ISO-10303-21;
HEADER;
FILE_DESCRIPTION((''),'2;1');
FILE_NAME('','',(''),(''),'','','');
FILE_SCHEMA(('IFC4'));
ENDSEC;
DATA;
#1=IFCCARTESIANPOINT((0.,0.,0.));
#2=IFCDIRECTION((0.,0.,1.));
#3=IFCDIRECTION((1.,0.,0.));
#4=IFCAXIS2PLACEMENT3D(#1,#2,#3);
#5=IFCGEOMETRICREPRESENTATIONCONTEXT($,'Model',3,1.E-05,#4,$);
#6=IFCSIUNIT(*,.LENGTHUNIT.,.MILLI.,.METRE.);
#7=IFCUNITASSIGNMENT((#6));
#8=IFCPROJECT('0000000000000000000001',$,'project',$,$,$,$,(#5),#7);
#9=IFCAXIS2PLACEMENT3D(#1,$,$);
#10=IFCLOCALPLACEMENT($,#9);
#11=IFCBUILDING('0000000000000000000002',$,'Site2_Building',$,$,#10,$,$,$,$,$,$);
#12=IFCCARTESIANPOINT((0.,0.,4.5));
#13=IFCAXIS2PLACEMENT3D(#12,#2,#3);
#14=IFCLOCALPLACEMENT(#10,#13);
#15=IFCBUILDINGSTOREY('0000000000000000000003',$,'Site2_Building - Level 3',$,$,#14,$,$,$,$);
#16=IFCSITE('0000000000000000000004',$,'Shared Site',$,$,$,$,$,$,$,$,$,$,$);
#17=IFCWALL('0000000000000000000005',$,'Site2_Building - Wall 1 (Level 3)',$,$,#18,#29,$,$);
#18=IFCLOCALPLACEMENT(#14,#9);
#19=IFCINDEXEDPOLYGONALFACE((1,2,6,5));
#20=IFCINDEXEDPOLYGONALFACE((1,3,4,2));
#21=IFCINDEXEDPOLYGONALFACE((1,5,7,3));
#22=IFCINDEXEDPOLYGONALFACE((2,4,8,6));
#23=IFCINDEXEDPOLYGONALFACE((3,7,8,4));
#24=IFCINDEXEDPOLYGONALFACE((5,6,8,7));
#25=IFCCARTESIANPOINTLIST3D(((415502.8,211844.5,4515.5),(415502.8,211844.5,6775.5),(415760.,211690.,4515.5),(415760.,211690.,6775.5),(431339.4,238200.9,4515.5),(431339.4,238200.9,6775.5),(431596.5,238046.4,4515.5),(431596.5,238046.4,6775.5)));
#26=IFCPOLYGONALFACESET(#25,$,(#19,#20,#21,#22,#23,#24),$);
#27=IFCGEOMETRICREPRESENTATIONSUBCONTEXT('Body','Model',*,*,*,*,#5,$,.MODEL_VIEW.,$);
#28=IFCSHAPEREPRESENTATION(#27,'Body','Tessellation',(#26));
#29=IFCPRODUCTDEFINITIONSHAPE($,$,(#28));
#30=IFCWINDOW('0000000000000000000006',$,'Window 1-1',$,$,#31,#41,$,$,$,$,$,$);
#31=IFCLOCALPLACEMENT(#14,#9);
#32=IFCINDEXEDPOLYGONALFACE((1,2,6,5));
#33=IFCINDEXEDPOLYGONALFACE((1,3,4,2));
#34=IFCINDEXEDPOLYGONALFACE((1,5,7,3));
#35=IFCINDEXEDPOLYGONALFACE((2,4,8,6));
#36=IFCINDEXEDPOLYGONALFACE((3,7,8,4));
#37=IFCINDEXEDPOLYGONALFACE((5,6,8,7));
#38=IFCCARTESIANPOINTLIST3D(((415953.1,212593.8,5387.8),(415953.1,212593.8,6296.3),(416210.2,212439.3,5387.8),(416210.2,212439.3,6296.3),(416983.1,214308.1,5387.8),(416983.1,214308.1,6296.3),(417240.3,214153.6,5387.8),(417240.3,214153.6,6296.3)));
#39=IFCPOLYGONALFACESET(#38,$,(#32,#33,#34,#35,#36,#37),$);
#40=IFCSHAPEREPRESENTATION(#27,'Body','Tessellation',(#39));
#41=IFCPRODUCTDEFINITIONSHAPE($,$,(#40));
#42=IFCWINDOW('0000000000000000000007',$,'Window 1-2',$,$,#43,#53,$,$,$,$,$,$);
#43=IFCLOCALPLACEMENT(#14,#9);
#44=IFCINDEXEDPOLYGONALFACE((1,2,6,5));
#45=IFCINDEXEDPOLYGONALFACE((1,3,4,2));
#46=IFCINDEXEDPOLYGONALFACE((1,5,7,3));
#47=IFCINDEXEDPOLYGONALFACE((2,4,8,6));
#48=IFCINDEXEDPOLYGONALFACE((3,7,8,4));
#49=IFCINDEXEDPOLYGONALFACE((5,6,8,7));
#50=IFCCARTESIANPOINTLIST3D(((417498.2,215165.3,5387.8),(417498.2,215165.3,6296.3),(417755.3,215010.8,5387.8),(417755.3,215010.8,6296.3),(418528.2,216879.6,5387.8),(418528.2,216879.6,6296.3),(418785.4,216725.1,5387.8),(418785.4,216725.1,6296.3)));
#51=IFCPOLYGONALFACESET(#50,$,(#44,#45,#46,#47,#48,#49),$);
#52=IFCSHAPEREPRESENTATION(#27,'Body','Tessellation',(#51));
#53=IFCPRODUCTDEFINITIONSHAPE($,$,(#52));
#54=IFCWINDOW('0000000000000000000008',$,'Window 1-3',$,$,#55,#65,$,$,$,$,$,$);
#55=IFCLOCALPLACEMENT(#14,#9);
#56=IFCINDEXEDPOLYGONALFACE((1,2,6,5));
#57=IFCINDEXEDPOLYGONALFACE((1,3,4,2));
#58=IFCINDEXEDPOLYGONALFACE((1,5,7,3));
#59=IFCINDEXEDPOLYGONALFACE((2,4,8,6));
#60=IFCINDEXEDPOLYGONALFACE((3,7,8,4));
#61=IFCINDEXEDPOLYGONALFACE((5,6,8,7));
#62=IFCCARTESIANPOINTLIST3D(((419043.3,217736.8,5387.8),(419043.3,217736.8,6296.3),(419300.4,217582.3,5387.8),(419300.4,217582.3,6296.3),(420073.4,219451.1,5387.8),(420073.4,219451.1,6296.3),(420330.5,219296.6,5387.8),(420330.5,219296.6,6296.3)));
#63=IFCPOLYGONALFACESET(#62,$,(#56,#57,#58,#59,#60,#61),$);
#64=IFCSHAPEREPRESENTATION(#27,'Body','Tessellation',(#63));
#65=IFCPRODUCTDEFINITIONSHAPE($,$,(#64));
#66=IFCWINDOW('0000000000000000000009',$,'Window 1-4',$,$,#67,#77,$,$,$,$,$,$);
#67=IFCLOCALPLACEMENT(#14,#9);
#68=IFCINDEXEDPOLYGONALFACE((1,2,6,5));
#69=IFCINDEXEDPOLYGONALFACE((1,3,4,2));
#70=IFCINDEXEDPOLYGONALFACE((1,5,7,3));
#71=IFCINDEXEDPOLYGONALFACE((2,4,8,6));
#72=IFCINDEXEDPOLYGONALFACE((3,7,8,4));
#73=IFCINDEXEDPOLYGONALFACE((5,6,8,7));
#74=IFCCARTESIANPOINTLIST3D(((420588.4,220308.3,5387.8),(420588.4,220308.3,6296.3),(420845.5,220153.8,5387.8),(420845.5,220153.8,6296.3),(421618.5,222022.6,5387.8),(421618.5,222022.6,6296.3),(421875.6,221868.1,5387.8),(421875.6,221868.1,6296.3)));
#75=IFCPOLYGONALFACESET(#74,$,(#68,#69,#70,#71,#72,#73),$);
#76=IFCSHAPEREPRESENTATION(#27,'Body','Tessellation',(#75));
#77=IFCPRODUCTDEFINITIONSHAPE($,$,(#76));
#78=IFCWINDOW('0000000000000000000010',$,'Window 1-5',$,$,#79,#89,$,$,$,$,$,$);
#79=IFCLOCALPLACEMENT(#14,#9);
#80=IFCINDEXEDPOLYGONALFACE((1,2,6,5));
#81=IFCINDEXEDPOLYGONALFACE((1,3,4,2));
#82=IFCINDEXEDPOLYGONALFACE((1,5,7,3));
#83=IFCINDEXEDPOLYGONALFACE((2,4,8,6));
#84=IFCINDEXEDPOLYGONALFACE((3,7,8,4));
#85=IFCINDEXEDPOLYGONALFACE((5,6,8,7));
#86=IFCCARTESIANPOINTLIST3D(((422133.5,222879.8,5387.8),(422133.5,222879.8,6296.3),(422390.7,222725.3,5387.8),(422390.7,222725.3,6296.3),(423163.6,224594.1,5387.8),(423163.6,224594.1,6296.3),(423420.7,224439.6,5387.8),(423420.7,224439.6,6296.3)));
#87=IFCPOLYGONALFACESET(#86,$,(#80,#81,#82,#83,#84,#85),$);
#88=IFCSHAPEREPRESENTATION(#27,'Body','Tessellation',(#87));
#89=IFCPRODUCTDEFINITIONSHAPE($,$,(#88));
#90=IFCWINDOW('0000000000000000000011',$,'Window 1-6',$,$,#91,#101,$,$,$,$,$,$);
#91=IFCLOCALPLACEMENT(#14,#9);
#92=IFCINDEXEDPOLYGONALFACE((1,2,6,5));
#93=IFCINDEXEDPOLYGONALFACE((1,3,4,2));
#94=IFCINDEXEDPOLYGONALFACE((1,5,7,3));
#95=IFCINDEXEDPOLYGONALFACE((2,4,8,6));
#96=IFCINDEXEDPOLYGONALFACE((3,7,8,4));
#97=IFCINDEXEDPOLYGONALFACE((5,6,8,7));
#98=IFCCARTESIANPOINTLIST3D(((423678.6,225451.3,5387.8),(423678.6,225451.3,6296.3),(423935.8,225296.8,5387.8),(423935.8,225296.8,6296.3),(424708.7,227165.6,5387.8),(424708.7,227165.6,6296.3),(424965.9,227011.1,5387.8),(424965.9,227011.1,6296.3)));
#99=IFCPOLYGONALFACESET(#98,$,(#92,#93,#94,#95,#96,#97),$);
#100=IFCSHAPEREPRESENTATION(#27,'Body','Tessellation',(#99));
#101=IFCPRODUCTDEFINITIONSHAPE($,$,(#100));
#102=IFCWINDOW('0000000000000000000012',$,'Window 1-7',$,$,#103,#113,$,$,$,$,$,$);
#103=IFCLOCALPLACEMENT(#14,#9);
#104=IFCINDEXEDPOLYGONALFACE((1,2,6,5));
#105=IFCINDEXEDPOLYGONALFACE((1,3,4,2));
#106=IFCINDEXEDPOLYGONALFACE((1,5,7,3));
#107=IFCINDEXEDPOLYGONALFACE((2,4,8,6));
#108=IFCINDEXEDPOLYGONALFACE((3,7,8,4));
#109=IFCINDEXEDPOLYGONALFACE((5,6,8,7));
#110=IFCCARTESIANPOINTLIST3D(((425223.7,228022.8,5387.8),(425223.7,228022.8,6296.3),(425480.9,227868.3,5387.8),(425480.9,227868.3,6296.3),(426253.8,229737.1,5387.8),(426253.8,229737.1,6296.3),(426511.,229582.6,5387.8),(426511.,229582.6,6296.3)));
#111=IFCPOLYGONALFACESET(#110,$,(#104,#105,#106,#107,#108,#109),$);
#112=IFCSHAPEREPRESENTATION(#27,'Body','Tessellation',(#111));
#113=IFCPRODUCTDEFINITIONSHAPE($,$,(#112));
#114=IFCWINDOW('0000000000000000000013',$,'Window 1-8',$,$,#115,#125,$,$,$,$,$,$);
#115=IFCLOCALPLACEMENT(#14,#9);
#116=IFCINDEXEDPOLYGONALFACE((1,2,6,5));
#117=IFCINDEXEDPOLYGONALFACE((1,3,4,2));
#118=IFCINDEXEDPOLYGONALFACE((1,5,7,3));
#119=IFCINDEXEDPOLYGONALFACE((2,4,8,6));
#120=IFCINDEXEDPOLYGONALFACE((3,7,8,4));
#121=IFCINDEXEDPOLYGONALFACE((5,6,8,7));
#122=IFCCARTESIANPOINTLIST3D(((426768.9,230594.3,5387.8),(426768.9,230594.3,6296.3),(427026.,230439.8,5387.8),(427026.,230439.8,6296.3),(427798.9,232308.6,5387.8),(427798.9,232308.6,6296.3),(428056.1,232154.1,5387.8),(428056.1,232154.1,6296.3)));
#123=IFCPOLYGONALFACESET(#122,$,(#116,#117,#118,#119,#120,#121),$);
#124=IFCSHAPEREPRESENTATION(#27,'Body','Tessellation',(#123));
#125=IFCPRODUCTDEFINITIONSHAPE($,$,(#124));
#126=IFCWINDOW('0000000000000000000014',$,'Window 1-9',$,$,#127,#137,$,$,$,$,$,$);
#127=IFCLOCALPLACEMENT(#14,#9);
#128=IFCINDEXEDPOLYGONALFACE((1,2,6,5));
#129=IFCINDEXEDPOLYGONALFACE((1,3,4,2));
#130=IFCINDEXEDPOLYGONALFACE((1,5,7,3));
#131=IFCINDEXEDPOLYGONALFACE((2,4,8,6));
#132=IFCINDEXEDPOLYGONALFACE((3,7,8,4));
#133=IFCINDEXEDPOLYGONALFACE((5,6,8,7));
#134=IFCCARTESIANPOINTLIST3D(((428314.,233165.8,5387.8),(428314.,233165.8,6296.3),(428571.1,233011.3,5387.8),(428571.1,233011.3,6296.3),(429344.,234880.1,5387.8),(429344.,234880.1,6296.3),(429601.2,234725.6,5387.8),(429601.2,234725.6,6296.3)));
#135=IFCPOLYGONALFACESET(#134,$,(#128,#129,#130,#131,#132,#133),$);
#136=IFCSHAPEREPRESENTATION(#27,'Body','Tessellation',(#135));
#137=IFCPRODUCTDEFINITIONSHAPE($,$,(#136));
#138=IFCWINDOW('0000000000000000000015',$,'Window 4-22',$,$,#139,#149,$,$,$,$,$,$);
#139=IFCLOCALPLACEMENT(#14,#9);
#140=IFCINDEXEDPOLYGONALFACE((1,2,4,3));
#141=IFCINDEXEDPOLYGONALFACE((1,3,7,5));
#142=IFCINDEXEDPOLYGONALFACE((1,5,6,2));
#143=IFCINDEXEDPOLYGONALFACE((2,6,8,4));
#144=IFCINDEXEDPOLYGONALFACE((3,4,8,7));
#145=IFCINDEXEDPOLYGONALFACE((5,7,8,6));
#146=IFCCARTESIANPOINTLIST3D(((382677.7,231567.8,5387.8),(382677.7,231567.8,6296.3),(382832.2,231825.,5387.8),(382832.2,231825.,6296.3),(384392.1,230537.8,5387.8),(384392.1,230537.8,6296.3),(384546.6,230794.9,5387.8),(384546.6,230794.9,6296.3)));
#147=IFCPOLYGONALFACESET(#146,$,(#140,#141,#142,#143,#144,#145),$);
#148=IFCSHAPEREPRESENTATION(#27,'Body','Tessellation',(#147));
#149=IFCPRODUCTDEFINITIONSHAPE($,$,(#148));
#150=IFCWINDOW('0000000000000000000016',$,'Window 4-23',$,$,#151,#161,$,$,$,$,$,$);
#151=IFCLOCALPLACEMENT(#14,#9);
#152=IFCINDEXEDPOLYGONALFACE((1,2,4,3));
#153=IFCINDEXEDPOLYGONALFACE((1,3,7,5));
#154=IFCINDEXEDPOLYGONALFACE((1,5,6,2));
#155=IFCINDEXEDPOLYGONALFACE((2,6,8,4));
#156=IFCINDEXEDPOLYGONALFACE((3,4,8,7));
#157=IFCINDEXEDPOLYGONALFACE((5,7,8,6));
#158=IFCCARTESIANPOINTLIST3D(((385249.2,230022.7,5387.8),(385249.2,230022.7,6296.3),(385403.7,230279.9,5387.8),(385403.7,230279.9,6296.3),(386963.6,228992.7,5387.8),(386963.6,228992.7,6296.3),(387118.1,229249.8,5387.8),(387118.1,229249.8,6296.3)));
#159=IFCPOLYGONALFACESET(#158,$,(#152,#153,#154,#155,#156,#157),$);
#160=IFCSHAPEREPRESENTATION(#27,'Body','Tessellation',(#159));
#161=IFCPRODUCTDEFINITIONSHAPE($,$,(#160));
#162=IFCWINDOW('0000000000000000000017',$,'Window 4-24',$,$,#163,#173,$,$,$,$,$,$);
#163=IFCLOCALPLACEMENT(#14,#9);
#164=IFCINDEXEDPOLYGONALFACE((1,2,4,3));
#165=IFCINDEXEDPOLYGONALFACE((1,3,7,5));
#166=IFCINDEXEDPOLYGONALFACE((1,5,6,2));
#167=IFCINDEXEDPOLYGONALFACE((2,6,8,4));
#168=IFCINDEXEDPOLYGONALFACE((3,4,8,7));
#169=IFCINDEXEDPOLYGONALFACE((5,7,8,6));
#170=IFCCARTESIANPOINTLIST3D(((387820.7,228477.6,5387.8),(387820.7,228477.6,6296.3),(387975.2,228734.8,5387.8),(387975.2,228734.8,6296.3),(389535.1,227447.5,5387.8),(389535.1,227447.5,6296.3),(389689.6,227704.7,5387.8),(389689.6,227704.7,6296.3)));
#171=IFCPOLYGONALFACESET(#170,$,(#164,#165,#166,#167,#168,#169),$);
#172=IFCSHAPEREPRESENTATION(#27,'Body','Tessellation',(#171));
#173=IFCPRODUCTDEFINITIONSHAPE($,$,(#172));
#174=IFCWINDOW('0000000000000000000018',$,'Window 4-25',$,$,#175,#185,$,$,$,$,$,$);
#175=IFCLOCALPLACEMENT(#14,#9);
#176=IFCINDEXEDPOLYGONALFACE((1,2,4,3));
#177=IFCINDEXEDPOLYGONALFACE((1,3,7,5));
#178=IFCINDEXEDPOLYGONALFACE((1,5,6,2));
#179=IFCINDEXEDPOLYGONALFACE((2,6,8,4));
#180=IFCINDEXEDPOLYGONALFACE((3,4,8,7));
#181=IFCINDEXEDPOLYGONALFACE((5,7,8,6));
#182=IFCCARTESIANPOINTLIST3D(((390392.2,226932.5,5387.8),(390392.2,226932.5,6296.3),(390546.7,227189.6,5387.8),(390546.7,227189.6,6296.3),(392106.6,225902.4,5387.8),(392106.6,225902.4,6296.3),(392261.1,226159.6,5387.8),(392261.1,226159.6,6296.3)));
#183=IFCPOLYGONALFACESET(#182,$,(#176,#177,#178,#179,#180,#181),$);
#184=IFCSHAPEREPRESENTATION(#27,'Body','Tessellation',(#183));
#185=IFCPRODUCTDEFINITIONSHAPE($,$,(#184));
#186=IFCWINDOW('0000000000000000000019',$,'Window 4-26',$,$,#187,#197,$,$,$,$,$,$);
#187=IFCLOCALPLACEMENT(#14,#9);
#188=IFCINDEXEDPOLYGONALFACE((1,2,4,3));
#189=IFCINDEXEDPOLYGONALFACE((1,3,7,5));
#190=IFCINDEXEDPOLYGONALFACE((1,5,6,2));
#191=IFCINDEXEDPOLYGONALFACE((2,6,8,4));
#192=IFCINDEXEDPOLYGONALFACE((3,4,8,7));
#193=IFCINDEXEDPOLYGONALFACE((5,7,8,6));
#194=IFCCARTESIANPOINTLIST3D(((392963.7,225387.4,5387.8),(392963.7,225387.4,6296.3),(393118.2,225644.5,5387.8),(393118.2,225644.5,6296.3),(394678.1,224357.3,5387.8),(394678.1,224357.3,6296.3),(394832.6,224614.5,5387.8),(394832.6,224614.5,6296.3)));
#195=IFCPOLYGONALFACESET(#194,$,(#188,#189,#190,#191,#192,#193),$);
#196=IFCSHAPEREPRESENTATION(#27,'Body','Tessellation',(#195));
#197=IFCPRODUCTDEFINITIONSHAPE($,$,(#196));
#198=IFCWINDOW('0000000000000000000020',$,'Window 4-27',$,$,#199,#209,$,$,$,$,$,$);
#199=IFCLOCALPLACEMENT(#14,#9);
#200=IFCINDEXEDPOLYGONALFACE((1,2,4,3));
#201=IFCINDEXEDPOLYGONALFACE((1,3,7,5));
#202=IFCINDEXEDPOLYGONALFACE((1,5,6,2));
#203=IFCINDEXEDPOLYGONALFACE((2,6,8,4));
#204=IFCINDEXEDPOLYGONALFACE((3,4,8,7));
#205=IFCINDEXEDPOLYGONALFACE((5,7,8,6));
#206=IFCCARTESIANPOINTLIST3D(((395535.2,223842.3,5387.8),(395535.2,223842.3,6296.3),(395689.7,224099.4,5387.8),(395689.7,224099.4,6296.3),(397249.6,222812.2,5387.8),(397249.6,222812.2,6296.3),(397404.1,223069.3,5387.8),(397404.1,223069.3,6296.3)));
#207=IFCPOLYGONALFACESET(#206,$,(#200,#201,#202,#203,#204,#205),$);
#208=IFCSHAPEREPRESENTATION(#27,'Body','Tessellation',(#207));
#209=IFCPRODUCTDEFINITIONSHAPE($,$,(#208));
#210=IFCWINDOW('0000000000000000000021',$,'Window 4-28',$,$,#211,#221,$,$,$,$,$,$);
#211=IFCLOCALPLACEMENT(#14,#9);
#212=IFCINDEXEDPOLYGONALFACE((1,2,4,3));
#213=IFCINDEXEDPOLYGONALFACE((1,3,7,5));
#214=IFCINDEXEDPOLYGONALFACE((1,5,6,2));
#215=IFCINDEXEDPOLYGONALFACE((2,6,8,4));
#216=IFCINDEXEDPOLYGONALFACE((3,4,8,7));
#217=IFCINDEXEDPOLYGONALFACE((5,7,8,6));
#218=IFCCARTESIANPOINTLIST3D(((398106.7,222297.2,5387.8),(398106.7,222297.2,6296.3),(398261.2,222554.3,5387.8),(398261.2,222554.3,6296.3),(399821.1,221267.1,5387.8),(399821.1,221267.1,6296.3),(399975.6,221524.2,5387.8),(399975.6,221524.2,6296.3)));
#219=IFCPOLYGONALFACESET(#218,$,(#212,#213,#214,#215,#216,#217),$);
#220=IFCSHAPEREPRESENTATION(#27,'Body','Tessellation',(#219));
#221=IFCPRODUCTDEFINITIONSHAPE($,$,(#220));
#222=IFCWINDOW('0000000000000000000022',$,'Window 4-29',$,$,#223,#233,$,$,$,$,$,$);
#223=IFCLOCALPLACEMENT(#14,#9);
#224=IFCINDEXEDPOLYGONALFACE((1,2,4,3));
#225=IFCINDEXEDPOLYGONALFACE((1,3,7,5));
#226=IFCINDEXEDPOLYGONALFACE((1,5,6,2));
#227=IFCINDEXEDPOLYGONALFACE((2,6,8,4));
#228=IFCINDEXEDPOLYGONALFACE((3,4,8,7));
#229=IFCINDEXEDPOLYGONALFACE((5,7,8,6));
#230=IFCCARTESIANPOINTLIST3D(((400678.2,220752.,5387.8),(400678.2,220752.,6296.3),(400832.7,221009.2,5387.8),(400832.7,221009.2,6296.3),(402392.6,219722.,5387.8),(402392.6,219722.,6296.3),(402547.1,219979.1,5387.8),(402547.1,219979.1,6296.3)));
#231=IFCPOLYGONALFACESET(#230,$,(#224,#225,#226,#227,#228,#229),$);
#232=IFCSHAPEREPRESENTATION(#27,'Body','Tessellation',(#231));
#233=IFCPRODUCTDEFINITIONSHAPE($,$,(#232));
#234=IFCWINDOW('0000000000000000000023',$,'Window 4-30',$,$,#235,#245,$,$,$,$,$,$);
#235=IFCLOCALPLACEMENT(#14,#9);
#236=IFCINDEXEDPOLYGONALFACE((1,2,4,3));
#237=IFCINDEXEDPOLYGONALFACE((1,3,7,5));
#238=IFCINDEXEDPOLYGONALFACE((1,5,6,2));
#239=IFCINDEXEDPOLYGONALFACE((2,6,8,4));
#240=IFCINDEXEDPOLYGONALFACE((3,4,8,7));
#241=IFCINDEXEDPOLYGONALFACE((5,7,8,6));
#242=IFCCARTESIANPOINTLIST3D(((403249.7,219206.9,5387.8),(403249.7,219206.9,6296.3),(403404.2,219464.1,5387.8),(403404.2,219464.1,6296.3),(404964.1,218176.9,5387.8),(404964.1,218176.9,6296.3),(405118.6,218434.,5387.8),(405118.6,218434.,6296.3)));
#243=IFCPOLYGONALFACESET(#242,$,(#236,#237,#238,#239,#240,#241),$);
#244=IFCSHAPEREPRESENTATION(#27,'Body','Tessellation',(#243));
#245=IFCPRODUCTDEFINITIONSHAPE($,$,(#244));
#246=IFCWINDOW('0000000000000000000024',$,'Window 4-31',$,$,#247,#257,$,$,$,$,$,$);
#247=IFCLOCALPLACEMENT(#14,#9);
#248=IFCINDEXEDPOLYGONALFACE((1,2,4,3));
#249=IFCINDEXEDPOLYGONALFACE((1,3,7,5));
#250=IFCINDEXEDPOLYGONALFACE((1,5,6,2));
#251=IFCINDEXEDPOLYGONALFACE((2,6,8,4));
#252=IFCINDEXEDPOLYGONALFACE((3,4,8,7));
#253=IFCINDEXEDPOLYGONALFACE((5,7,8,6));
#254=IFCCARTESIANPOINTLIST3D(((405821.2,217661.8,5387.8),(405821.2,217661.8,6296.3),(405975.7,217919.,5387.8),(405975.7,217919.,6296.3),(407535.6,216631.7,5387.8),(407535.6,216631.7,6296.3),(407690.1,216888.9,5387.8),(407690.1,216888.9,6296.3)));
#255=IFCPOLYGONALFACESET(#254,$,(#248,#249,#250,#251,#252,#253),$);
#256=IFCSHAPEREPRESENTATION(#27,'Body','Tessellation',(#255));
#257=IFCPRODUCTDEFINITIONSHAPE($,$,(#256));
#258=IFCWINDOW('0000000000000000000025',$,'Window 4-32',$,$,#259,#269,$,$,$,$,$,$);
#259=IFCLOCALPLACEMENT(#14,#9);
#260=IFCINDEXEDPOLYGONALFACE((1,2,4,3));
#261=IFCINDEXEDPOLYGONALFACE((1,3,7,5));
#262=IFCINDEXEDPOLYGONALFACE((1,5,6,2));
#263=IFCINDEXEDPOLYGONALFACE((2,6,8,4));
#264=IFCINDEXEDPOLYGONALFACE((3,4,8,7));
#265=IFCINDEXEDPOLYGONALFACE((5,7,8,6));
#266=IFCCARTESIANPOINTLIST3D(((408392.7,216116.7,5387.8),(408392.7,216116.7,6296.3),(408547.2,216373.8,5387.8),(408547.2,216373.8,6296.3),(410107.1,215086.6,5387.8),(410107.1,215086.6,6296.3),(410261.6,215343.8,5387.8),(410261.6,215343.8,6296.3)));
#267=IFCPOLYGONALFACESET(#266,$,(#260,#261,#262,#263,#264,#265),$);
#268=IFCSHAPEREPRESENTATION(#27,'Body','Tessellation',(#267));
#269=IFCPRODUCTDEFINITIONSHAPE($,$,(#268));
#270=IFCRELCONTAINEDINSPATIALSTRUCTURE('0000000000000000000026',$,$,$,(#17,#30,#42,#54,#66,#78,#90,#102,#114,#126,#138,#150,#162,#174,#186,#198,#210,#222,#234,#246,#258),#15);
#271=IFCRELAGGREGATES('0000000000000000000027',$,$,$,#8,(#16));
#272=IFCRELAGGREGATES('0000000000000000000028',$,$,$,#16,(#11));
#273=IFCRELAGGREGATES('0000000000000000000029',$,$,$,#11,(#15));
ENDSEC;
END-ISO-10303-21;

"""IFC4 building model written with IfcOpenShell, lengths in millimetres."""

from ifc_helpers import new_model, si_unit, frame, origin, origin_with_axes, place, context, subcontext, project, spatial, indexed_curve, outline, extrude, element, save


model = new_model("IFC4")

# Units and contexts
model_context = context("Model", 3, precision=1e-05, world=origin_with_axes())
body_context = subcontext(model_context, "Body", "Model", "MODEL_VIEW")
ifc_project = project(units=[si_unit("LENGTHUNIT", "METRE", prefix="MILLI")], contexts=[model_context])

# Site, building, storey
site = spatial("IfcSite", under=ifc_project, Name="Shared Site")
building_placement = place(None, origin())
building = spatial("IfcBuilding", under=site, at=building_placement, Name="Site2_Building")
storey_placement = place(building_placement, frame((0.0, 0.0, 4.5), z_axis=(0.0, 0.0, 1.0), x_axis=(1.0, 0.0, 0.0)))
storey = spatial("IfcBuildingStorey", under=building, at=storey_placement, Name="Site2_Building - Level 3")

# Wall
wall_placement = place(storey_placement, frame((415760.0, 211690.0, 4515.5), z_axis=(0.0, 0.0, 1.0), x_axis=(0.515038, 0.857167, 0.0)))
element("IfcWall", 1, at=wall_placement, inside=storey, Name="Site2_Building - Wall 1 (Level 3)", context=body_context, shape_type="SweptSolid", body=[
    extrude(outline(indexed_curve([(0.0, 0.0), (0.0, 300.0), (30748.2, 300.0), (30748.2, 0.0), (0.0, 0.0)], self_intersect=False)), origin_with_axes(), (0.0, 0.0, 1.0), 2260.0),
])

# Windows
for number, where, z_axis, x_axis, name in (
    (2, (416210.2, 212439.3, 5387.8), (0.0, 0.0, 1.0), (0.515038, 0.857167, 0.0), "Window 1-1"),
    (3, (417755.3, 215010.8, 5387.8), (0.0, 0.0, 1.0), (0.515038, 0.857167, 0.0), "Window 1-2"),
    (4, (419300.4, 217582.3, 5387.8), (0.0, 0.0, 1.0), (0.515038, 0.857167, 0.0), "Window 1-3"),
    (5, (420845.5, 220153.8, 5387.8), (0.0, 0.0, 1.0), (0.515038, 0.857167, 0.0), "Window 1-4"),
    (6, (422390.7, 222725.3, 5387.8), (0.0, 0.0, 1.0), (0.515038, 0.857167, 0.0), "Window 1-5"),
    (7, (423935.8, 225296.8, 5387.8), (0.0, 0.0, 1.0), (0.515038, 0.857167, 0.0), "Window 1-6"),
    (8, (425480.9, 227868.3, 5387.8), (0.0, 0.0, 1.0), (0.515038, 0.857167, 0.0), "Window 1-7"),
    (9, (427026.0, 230439.8, 5387.8), (0.0, 0.0, 1.0), (0.515038, 0.857167, 0.0), "Window 1-8"),
    (10, (428571.1, 233011.3, 5387.8), (0.0, 0.0, 1.0), (0.515038, 0.857167, 0.0), "Window 1-9"),
    (11, (382677.7, 231567.8, 5387.8), (0.0, 0.0, 1.0), (0.857167, -0.515038, 0.0), "Window 4-22"),
    (12, (385249.2, 230022.7, 5387.8), (0.0, 0.0, 1.0), (0.857167, -0.515038, 0.0), "Window 4-23"),
    (13, (387820.7, 228477.6, 5387.8), (0.0, 0.0, 1.0), (0.857167, -0.515038, 0.0), "Window 4-24"),
    (14, (390392.2, 226932.5, 5387.8), (0.0, 0.0, 1.0), (0.857167, -0.515038, 0.0), "Window 4-25"),
    (15, (392963.7, 225387.4, 5387.8), (0.0, 0.0, 1.0), (0.857167, -0.515038, 0.0), "Window 4-26"),
    (16, (395535.2, 223842.3, 5387.8), (0.0, 0.0, 1.0), (0.857167, -0.515038, 0.0), "Window 4-27"),
    (17, (398106.7, 222297.2, 5387.8), (0.0, 0.0, 1.0), (0.857167, -0.515038, 0.0), "Window 4-28"),
    (18, (400678.2, 220752.0, 5387.8), (0.0, 0.0, 1.0), (0.857167, -0.515038, 0.0), "Window 4-29"),
    (19, (403249.7, 219206.9, 5387.8), (0.0, 0.0, 1.0), (0.857167, -0.515038, 0.0), "Window 4-30"),
    (20, (405821.2, 217661.8, 5387.8), (0.0, 0.0, 1.0), (0.857167, -0.515038, 0.0), "Window 4-31"),
    (21, (408392.7, 216116.7, 5387.8), (0.0, 0.0, 1.0), (0.857167, -0.515038, 0.0), "Window 4-32"),
):
    element("IfcWindow", number, at=place(storey_placement, frame(where, z_axis=z_axis, x_axis=x_axis)), inside=storey, Name=name, context=body_context, shape_type="SweptSolid", body=[
        extrude(outline(indexed_curve([(0.0, 0.0), (0.0, 300.0), (2000.0, 300.0), (2000.0, 0.0), (0.0, 0.0)], self_intersect=False)), origin_with_axes(), (0.0, 0.0, 1.0), 908.6),
    ])

save(model, "model.ifc")
